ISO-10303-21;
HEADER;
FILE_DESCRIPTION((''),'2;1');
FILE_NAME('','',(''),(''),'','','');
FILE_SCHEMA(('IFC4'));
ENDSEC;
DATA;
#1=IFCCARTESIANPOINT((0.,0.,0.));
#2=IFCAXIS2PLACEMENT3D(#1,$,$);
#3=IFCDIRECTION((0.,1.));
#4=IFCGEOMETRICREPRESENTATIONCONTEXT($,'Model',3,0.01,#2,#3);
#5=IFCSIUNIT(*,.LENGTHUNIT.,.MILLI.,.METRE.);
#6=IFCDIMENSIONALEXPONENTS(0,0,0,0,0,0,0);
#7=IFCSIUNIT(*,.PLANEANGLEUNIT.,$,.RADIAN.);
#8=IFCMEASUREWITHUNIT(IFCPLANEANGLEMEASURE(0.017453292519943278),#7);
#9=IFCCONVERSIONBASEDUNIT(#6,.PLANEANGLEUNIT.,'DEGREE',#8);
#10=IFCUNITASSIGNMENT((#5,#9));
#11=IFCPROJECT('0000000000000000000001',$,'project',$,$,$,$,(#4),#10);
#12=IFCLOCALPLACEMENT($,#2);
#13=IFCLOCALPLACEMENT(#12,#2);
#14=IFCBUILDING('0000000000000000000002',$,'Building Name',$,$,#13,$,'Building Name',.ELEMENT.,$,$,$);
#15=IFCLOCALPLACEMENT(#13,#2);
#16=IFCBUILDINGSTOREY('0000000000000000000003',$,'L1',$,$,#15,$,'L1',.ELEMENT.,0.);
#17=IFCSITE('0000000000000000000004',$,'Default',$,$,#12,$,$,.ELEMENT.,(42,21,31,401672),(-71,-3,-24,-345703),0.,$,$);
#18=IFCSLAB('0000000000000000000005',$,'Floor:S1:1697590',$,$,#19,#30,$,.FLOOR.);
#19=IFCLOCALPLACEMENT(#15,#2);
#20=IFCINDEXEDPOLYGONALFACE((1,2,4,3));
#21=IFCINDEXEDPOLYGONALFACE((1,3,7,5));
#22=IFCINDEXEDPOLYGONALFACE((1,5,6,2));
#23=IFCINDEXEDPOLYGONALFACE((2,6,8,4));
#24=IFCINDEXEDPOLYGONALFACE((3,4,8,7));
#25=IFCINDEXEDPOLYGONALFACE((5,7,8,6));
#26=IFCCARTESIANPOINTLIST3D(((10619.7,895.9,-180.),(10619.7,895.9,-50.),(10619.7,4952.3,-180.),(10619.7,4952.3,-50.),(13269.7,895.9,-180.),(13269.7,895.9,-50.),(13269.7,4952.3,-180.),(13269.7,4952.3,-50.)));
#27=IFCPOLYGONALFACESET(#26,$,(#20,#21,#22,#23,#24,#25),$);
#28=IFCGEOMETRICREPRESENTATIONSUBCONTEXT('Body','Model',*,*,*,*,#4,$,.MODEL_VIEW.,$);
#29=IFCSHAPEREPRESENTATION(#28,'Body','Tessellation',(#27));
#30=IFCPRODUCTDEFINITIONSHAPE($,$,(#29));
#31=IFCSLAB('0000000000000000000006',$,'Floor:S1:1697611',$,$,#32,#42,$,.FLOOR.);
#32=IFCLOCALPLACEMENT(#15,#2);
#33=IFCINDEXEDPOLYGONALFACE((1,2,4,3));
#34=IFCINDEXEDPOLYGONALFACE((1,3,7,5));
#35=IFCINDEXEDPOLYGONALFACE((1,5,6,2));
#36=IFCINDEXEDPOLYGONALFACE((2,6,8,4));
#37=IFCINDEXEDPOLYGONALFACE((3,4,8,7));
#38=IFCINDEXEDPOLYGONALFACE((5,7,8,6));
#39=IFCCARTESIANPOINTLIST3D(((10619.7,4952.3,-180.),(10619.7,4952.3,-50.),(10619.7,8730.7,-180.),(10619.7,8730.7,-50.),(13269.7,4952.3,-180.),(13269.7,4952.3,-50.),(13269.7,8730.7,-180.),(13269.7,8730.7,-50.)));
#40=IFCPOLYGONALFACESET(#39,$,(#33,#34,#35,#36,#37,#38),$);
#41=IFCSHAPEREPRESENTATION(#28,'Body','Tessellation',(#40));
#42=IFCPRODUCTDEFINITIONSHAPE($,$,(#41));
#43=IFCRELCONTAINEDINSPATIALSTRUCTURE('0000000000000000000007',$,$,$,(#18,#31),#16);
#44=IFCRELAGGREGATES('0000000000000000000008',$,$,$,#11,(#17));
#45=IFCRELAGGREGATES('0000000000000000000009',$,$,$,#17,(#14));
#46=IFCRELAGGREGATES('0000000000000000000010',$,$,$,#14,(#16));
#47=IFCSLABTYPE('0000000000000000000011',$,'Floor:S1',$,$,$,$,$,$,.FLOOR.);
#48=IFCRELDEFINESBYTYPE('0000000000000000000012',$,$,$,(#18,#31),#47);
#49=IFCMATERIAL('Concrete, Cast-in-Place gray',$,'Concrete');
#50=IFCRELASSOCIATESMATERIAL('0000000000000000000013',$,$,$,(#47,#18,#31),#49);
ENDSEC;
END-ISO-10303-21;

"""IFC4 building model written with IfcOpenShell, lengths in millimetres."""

from ifc_helpers import new_model, entity, si_unit, converted_unit, direction, frame, origin, place, context, subcontext, project, spatial, indexed_curve, outline, extrude, material, type_object, element, save


model = new_model("IFC4")

# Units and contexts
model_context = context("Model", 3, precision=0.01, world=origin(), true_north=direction((0.0, 1.0)))
body_context = subcontext(model_context, "Body", "Model", "MODEL_VIEW")
ifc_project = project(units=[si_unit("LENGTHUNIT", "METRE", prefix="MILLI"), converted_unit("PLANEANGLEUNIT", "DEGREE", entity("IfcPlaneAngleMeasure", 0.017453292519943278), si_unit("PLANEANGLEUNIT", "RADIAN"), dimensions=[0, 0, 0, 0, 0, 0, 0])], contexts=[model_context])

# Site, building, storey
site_placement = place(None, origin())
site = spatial("IfcSite", under=ifc_project, at=site_placement, Name="Default", CompositionType="ELEMENT", RefLatitude=(42, 21, 31, 401672), RefLongitude=(-71, -3, -24, -345703), RefElevation=0.0)
building_placement = place(site_placement, origin())
building = spatial("IfcBuilding", under=site, at=building_placement, Name="Building Name", LongName="Building Name", CompositionType="ELEMENT")
storey_placement = place(building_placement, origin())
storey = spatial("IfcBuildingStorey", under=building, at=storey_placement, Name="L1", LongName="L1", CompositionType="ELEMENT", Elevation=0.0)

# Slabs
ifc_material = material(Name="Concrete, Cast-in-Place gray", Category="Concrete")
slab_type = type_object("IfcSlabType", Name="Floor:S1", PredefinedType="FLOOR", material=ifc_material)
slab_1_placement = place(storey_placement, origin())
element("IfcSlab", 1, at=slab_1_placement, inside=storey, type_object=slab_type, material=ifc_material, Name="Floor:S1:1697590", PredefinedType="FLOOR", context=body_context, shape_type="SweptSolid", body=[
    extrude(outline(indexed_curve([(-2028.2, -1325.0), (2028.2, -1325.0), (2028.2, 1325.0), (-2028.2, 1325.0), (-2028.2, -1325.0)], self_intersect=False)), frame((11944.7, 2924.1, -50.0), z_axis=(0.0, 0.0, -1.0), x_axis=(0.0, 1.0, 0.0)), (0.0, 0.0, 1.0), 130.0),
])
slab_2_placement = place(storey_placement, origin())
element("IfcSlab", 2, at=slab_2_placement, inside=storey, type_object=slab_type, material=ifc_material, Name="Floor:S1:1697611", PredefinedType="FLOOR", context=body_context, shape_type="SweptSolid", body=[
    extrude(outline(indexed_curve([(-1889.2, -1325.0), (1889.2, -1325.0), (1889.2, 1325.0), (-1889.2, 1325.0), (-1889.2, -1325.0)], self_intersect=False)), frame((11944.7, 6841.5, -50.0), z_axis=(0.0, 0.0, -1.0), x_axis=(0.0, 1.0, 0.0)), (0.0, 0.0, 1.0), 130.0),
])

save(model, "model.ifc")
